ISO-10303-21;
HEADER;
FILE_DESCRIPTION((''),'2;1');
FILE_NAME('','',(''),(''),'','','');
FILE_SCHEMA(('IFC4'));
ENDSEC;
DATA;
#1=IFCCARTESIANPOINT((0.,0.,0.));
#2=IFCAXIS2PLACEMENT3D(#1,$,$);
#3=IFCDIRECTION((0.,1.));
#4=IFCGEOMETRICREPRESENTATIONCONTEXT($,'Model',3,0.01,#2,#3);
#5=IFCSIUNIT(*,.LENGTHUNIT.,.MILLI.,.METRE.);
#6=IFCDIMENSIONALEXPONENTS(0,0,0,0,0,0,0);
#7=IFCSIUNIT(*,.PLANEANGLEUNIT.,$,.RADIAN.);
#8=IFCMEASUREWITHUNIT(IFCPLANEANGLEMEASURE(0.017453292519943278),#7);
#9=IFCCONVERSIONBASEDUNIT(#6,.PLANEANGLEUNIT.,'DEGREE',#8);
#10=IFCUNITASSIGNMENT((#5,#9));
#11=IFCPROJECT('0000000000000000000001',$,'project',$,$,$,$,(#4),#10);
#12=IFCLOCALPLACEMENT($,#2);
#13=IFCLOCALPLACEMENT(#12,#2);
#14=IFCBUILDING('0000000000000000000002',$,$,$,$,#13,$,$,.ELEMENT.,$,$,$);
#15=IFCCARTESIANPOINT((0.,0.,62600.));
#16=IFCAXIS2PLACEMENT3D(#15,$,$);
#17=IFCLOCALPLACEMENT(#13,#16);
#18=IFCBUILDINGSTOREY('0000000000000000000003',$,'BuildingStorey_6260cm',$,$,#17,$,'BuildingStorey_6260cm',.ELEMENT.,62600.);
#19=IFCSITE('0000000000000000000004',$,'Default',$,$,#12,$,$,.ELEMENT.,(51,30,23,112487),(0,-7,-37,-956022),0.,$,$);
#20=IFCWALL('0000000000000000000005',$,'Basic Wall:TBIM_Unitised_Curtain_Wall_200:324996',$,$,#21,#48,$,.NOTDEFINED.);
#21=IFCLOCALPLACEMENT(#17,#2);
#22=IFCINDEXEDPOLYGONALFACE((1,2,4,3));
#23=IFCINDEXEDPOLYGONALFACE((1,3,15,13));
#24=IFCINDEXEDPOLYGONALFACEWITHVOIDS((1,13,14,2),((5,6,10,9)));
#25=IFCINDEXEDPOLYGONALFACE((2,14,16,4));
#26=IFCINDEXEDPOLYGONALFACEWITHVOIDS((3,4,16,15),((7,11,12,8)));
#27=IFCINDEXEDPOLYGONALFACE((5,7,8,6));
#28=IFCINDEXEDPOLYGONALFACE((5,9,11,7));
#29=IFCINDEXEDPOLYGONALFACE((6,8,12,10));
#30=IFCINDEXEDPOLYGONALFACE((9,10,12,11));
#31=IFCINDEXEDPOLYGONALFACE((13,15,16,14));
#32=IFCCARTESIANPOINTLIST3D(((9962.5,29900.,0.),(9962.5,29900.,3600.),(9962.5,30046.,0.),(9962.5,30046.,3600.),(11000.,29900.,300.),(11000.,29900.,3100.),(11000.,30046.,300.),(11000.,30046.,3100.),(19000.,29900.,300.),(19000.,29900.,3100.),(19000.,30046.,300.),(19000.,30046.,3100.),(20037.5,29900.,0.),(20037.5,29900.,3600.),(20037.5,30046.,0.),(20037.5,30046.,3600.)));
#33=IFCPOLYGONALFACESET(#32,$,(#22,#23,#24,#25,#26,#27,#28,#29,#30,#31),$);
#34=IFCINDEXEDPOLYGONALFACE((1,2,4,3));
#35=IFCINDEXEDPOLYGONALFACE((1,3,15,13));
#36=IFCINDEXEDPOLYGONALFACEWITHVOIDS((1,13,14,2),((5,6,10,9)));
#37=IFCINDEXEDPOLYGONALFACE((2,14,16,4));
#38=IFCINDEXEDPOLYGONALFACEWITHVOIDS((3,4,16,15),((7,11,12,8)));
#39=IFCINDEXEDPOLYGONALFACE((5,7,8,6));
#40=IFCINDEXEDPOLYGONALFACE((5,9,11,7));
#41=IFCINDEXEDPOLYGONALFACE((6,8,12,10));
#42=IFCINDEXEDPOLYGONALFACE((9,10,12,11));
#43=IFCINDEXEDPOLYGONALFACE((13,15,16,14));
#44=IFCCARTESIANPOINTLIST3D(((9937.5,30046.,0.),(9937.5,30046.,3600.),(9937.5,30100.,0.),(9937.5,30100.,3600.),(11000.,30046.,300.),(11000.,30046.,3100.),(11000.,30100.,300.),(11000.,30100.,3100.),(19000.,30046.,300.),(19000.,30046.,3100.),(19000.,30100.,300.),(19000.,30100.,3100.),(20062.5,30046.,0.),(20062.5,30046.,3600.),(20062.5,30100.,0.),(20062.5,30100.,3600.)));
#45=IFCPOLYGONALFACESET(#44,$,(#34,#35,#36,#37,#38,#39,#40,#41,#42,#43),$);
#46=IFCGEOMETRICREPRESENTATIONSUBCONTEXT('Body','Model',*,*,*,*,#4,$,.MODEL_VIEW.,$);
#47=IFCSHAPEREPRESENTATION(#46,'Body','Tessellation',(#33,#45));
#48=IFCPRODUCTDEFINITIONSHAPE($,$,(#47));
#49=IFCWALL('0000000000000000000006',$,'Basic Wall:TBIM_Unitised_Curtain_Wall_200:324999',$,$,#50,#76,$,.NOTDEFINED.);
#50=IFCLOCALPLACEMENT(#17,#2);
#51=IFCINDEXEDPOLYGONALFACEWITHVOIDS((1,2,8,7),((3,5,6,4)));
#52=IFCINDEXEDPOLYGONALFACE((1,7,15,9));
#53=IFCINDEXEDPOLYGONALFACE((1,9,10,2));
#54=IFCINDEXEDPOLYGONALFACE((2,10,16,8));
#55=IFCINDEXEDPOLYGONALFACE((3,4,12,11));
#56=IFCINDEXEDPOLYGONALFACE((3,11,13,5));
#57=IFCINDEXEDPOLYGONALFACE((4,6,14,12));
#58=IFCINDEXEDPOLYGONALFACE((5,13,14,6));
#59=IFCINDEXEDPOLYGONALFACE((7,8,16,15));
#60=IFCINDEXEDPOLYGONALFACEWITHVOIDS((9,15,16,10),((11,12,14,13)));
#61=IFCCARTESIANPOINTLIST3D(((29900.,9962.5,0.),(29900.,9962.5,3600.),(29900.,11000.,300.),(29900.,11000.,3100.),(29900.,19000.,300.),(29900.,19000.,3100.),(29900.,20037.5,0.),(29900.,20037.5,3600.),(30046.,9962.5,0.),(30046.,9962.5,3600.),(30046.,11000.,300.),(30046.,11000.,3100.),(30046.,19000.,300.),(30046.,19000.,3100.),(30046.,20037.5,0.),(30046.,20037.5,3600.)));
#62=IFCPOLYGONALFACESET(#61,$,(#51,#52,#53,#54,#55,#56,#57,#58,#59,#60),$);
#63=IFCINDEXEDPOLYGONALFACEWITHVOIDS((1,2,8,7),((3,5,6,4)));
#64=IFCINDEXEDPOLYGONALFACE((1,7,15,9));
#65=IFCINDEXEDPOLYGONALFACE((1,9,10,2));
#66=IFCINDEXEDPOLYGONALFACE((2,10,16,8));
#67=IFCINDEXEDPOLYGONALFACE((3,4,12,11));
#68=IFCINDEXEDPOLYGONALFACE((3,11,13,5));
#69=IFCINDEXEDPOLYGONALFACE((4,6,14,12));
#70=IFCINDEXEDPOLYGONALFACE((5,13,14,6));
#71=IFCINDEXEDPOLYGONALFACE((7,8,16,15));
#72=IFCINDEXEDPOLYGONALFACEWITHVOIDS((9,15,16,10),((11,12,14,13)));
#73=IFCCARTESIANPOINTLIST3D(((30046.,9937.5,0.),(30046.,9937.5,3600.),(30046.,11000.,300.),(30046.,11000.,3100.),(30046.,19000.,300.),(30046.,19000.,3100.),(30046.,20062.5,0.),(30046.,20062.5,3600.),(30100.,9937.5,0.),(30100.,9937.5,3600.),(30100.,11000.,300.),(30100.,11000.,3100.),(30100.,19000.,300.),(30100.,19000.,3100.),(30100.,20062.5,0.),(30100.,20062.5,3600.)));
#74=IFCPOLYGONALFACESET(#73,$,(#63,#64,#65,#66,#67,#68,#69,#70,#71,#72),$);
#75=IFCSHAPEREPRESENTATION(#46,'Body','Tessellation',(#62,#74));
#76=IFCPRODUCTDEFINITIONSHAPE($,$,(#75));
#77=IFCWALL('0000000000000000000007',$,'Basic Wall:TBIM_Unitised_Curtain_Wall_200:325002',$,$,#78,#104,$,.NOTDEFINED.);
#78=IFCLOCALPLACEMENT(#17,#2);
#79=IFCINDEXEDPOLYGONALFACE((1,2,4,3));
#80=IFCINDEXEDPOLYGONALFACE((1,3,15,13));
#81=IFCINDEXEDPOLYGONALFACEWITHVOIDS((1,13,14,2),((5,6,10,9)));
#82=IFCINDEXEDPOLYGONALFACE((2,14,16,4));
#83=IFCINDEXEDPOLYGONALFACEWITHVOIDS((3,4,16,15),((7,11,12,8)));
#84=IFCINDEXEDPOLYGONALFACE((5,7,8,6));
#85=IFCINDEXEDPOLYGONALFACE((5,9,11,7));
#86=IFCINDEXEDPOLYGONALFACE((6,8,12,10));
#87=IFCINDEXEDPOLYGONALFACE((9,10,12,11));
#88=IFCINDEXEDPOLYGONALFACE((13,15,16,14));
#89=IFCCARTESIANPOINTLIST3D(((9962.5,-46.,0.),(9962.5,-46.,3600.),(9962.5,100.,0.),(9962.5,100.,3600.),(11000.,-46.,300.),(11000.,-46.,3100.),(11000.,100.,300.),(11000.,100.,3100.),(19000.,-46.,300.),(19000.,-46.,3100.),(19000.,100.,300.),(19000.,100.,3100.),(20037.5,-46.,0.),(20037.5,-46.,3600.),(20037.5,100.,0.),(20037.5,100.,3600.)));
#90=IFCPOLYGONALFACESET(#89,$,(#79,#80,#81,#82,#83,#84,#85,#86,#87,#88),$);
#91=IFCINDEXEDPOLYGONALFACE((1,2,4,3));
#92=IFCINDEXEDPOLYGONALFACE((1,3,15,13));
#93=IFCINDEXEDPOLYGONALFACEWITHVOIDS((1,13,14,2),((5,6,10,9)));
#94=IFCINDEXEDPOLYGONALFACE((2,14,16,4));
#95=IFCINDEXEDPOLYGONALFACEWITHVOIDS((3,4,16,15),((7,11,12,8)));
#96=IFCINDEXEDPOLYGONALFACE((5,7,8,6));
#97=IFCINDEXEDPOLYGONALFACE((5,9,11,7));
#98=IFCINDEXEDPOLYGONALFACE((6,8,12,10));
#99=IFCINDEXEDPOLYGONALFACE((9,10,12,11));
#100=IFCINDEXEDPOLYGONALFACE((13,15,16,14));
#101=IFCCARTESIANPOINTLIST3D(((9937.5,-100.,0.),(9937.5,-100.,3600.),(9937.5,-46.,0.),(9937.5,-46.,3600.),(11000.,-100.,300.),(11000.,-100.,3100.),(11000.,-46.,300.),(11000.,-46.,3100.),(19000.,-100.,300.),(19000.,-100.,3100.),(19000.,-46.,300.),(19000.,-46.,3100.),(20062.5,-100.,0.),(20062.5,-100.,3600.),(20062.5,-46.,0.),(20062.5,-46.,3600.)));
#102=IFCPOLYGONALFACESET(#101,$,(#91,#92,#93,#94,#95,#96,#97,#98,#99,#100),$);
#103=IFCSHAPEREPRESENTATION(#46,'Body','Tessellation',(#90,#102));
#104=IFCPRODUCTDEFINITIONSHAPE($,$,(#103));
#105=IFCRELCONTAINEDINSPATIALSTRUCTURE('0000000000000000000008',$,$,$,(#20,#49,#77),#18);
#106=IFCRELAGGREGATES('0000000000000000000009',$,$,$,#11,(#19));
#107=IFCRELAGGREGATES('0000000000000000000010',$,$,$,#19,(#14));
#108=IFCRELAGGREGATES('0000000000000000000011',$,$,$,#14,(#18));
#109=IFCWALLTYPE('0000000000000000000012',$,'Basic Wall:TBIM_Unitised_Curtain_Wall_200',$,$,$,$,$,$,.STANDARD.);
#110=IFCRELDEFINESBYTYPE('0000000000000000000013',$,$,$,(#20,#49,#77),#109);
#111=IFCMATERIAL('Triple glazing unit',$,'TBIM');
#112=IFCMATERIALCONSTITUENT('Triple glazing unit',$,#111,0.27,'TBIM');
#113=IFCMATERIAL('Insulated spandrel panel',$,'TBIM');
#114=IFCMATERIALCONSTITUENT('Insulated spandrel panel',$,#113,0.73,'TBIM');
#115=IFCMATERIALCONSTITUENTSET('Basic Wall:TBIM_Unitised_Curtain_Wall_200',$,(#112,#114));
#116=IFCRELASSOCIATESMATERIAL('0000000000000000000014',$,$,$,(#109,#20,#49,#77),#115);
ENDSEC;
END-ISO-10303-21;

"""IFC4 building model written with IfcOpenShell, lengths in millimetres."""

from ifc_helpers import new_model, entity, si_unit, converted_unit, direction, frame, origin, place, context, subcontext, project, spatial, indexed_curve, outline, extrude, material, constituent, constituent_set, type_object, element, save


model = new_model("IFC4")

# Units and contexts
model_context = context("Model", 3, precision=0.01, world=origin(), true_north=direction((0.0, 1.0)))
body_context = subcontext(model_context, "Body", "Model", "MODEL_VIEW")
ifc_project = project(units=[si_unit("LENGTHUNIT", "METRE", prefix="MILLI"), converted_unit("PLANEANGLEUNIT", "DEGREE", entity("IfcPlaneAngleMeasure", 0.017453292519943278), si_unit("PLANEANGLEUNIT", "RADIAN"), dimensions=[0, 0, 0, 0, 0, 0, 0])], contexts=[model_context])

# Site, building, storey
site_placement = place(None, origin())
site = spatial("IfcSite", under=ifc_project, at=site_placement, Name="Default", CompositionType="ELEMENT", RefLatitude=(51, 30, 23, 112487), RefLongitude=(0, -7, -37, -956022), RefElevation=0.0)
building_placement = place(site_placement, origin())
building = spatial("IfcBuilding", under=site, at=building_placement, CompositionType="ELEMENT")
storey_placement = place(building_placement, frame((0.0, 0.0, 62600.0)))
storey = spatial("IfcBuildingStorey", under=building, at=storey_placement, Name="BuildingStorey_6260cm", LongName="BuildingStorey_6260cm", CompositionType="ELEMENT", Elevation=62600.0)

# Walls, openings
ifc_material_1 = material(Name="Triple glazing unit", Category="TBIM")
ifc_constituent_1 = constituent(ifc_material_1, Name="Triple glazing unit", Category="TBIM", fraction=0.27)
ifc_material_2 = material(Name="Insulated spandrel panel", Category="TBIM")
ifc_constituent_2 = constituent(ifc_material_2, Name="Insulated spandrel panel", Category="TBIM", fraction=0.73)
ifc_constituent_set_1 = constituent_set(constituents=[ifc_constituent_1, ifc_constituent_2], Name="Basic Wall:TBIM_Unitised_Curtain_Wall_200")
wall_type_1 = type_object("IfcWallType", Name="Basic Wall:TBIM_Unitised_Curtain_Wall_200", PredefinedType="STANDARD", material=ifc_constituent_set_1)
wall_1_placement = place(storey_placement, frame((9937.5, 30000.0, 0.0)))
wall_1 = element("IfcWall", 1, at=wall_1_placement, inside=storey, type_object=wall_type_1, material=ifc_constituent_set_1, Name="Basic Wall:TBIM_Unitised_Curtain_Wall_200:324996", PredefinedType="NOTDEFINED", context=body_context, shape_type="SweptSolid", body=[
    extrude(outline(indexed_curve([(-1800.0, -5037.5), (1800.0, -5037.5), (1800.0, -4937.5), (1800.0, 4937.5), (1800.0, 5037.5), (-1800.0, 5037.5), (-1800.0, 4937.5), (-1800.0, -4937.5), (-1800.0, -5037.5)], self_intersect=False), holes=[indexed_curve([(1300.0, -4000.0), (-1500.0, -4000.0), (-1500.0, 4000.0), (1300.0, 4000.0), (1300.0, -4000.0)], self_intersect=False)]), frame((5062.5, -100.0, 1800.0), z_axis=(0.0, 1.0, 0.0), x_axis=(0.0, 0.0, 1.0)), (0.0, 0.0, 1.0), 146.0),
    extrude(outline(indexed_curve([(-1800.0, -5062.5), (1800.0, -5062.5), (1800.0, 5062.5), (-1800.0, 5062.5), (-1800.0, -5062.5)], self_intersect=False), holes=[indexed_curve([(-1500.0, -4000.0), (-1500.0, 4000.0), (1300.0, 4000.0), (1300.0, -4000.0), (-1500.0, -4000.0)], self_intersect=False)]), frame((5062.5, 46.0, 1800.0), z_axis=(0.0, 1.0, 0.0), x_axis=(0.0, 0.0, 1.0)), (0.0, 0.0, 1.0), 54.0),
])
opening_1_placement = place(wall_1_placement, frame((1062.5, -100.0, 300.0)))
element("IfcOpeningElement", 2, at=opening_1_placement, cuts=wall_1, PredefinedType="OPENING", context=body_context, shape_type="SweptSolid", body=[
    extrude(outline(indexed_curve([(2800.0, 0.0), (2800.0, 8000.0), (0.0, 8000.0), (0.0, 0.0), (2800.0, 0.0)], self_intersect=False)), frame((0.0, 0.0, 0.0), z_axis=(0.0, 1.0, 0.0), x_axis=(0.0, 0.0, 1.0)), (0.0, 0.0, 1.0), 200.0),
])
wall_2_placement = place(storey_placement, frame((30000.0, 9937.5, 0.0), z_axis=(0.0, 0.0, 1.0), x_axis=(0.0, 1.0, 0.0)))
wall_2 = element("IfcWall", 3, at=wall_2_placement, inside=storey, type_object=wall_type_1, material=ifc_constituent_set_1, Name="Basic Wall:TBIM_Unitised_Curtain_Wall_200:324999", PredefinedType="NOTDEFINED", context=body_context, shape_type="SweptSolid", body=[
    extrude(outline(indexed_curve([(-5037.5, -1800.0), (-4937.5, -1800.0), (4937.5, -1800.0), (5037.5, -1800.0), (5037.5, 1800.0), (4937.5, 1800.0), (-4937.5, 1800.0), (-5037.5, 1800.0), (-5037.5, -1800.0)], self_intersect=False), holes=[indexed_curve([(-4000.0, 1300.0), (4000.0, 1300.0), (4000.0, -1500.0), (-4000.0, -1500.0), (-4000.0, 1300.0)], self_intersect=False)]), frame((5062.5, 100.0, 1800.0), z_axis=(0.0, -1.0, 0.0), x_axis=(1.0, 0.0, 0.0)), (0.0, 0.0, 1.0), 146.0),
    extrude(outline(indexed_curve([(-1800.0, -5062.5), (1800.0, -5062.5), (1800.0, 5062.5), (-1800.0, 5062.5), (-1800.0, -5062.5)], self_intersect=False), holes=[indexed_curve([(1300.0, 4000.0), (1300.0, -4000.0), (-1500.0, -4000.0), (-1500.0, 4000.0), (1300.0, 4000.0)], self_intersect=False)]), frame((5062.5, -46.0, 1800.0), z_axis=(0.0, -1.0, 0.0), x_axis=(0.0, 0.0, 1.0)), (0.0, 0.0, 1.0), 54.0),
])
opening_2_placement = place(wall_2_placement, frame((1062.5, -100.0, 300.0)))
element("IfcOpeningElement", 4, at=opening_2_placement, cuts=wall_2, PredefinedType="OPENING", context=body_context, shape_type="SweptSolid", body=[
    extrude(outline(indexed_curve([(2800.0, 0.0), (2800.0, 8000.0), (0.0, 8000.0), (0.0, 0.0), (2800.0, 0.0)], self_intersect=False)), frame((0.0, 0.0, 0.0), z_axis=(0.0, 1.0, 0.0), x_axis=(0.0, 0.0, 1.0)), (0.0, 0.0, 1.0), 200.0),
])
wall_3_placement = place(storey_placement, frame((9937.5, 0.0, 0.0)))
wall_3 = element("IfcWall", 5, at=wall_3_placement, inside=storey, type_object=wall_type_1, material=ifc_constituent_set_1, Name="Basic Wall:TBIM_Unitised_Curtain_Wall_200:325002", PredefinedType="NOTDEFINED", context=body_context, shape_type="SweptSolid", body=[
    extrude(outline(indexed_curve([(-1800.0, -5037.5), (1800.0, -5037.5), (1800.0, 5037.5), (-1800.0, 5037.5), (-1800.0, -5037.5)], self_intersect=False), holes=[indexed_curve([(-1500.0, -4000.0), (-1500.0, 4000.0), (1300.0, 4000.0), (1300.0, -4000.0), (-1500.0, -4000.0)], self_intersect=False)]), frame((5062.5, -46.0, 1800.0), z_axis=(0.0, 1.0, 0.0), x_axis=(0.0, 0.0, 1.0)), (0.0, 0.0, 1.0), 146.0),
    extrude(outline(indexed_curve([(-1800.0, -5062.5), (1800.0, -5062.5), (1800.0, 5062.5), (-1800.0, 5062.5), (-1800.0, -5062.5)], self_intersect=False), holes=[indexed_curve([(1300.0, -4000.0), (-1500.0, -4000.0), (-1500.0, 4000.0), (1300.0, 4000.0), (1300.0, -4000.0)], self_intersect=False)]), frame((5062.5, -100.0, 1800.0), z_axis=(0.0, 1.0, 0.0), x_axis=(0.0, 0.0, 1.0)), (0.0, 0.0, 1.0), 54.0),
])
opening_3_placement = place(wall_3_placement, frame((1062.5, -100.0, 300.0)))
element("IfcOpeningElement", 6, at=opening_3_placement, cuts=wall_3, PredefinedType="OPENING", context=body_context, shape_type="SweptSolid", body=[
    extrude(outline(indexed_curve([(2800.0, 0.0), (2800.0, 8000.0), (0.0, 8000.0), (0.0, 0.0), (2800.0, 0.0)], self_intersect=False)), frame((0.0, 0.0, 0.0), z_axis=(0.0, 1.0, 0.0), x_axis=(0.0, 0.0, 1.0)), (0.0, 0.0, 1.0), 200.0),
])

save(model, "model.ifc")
